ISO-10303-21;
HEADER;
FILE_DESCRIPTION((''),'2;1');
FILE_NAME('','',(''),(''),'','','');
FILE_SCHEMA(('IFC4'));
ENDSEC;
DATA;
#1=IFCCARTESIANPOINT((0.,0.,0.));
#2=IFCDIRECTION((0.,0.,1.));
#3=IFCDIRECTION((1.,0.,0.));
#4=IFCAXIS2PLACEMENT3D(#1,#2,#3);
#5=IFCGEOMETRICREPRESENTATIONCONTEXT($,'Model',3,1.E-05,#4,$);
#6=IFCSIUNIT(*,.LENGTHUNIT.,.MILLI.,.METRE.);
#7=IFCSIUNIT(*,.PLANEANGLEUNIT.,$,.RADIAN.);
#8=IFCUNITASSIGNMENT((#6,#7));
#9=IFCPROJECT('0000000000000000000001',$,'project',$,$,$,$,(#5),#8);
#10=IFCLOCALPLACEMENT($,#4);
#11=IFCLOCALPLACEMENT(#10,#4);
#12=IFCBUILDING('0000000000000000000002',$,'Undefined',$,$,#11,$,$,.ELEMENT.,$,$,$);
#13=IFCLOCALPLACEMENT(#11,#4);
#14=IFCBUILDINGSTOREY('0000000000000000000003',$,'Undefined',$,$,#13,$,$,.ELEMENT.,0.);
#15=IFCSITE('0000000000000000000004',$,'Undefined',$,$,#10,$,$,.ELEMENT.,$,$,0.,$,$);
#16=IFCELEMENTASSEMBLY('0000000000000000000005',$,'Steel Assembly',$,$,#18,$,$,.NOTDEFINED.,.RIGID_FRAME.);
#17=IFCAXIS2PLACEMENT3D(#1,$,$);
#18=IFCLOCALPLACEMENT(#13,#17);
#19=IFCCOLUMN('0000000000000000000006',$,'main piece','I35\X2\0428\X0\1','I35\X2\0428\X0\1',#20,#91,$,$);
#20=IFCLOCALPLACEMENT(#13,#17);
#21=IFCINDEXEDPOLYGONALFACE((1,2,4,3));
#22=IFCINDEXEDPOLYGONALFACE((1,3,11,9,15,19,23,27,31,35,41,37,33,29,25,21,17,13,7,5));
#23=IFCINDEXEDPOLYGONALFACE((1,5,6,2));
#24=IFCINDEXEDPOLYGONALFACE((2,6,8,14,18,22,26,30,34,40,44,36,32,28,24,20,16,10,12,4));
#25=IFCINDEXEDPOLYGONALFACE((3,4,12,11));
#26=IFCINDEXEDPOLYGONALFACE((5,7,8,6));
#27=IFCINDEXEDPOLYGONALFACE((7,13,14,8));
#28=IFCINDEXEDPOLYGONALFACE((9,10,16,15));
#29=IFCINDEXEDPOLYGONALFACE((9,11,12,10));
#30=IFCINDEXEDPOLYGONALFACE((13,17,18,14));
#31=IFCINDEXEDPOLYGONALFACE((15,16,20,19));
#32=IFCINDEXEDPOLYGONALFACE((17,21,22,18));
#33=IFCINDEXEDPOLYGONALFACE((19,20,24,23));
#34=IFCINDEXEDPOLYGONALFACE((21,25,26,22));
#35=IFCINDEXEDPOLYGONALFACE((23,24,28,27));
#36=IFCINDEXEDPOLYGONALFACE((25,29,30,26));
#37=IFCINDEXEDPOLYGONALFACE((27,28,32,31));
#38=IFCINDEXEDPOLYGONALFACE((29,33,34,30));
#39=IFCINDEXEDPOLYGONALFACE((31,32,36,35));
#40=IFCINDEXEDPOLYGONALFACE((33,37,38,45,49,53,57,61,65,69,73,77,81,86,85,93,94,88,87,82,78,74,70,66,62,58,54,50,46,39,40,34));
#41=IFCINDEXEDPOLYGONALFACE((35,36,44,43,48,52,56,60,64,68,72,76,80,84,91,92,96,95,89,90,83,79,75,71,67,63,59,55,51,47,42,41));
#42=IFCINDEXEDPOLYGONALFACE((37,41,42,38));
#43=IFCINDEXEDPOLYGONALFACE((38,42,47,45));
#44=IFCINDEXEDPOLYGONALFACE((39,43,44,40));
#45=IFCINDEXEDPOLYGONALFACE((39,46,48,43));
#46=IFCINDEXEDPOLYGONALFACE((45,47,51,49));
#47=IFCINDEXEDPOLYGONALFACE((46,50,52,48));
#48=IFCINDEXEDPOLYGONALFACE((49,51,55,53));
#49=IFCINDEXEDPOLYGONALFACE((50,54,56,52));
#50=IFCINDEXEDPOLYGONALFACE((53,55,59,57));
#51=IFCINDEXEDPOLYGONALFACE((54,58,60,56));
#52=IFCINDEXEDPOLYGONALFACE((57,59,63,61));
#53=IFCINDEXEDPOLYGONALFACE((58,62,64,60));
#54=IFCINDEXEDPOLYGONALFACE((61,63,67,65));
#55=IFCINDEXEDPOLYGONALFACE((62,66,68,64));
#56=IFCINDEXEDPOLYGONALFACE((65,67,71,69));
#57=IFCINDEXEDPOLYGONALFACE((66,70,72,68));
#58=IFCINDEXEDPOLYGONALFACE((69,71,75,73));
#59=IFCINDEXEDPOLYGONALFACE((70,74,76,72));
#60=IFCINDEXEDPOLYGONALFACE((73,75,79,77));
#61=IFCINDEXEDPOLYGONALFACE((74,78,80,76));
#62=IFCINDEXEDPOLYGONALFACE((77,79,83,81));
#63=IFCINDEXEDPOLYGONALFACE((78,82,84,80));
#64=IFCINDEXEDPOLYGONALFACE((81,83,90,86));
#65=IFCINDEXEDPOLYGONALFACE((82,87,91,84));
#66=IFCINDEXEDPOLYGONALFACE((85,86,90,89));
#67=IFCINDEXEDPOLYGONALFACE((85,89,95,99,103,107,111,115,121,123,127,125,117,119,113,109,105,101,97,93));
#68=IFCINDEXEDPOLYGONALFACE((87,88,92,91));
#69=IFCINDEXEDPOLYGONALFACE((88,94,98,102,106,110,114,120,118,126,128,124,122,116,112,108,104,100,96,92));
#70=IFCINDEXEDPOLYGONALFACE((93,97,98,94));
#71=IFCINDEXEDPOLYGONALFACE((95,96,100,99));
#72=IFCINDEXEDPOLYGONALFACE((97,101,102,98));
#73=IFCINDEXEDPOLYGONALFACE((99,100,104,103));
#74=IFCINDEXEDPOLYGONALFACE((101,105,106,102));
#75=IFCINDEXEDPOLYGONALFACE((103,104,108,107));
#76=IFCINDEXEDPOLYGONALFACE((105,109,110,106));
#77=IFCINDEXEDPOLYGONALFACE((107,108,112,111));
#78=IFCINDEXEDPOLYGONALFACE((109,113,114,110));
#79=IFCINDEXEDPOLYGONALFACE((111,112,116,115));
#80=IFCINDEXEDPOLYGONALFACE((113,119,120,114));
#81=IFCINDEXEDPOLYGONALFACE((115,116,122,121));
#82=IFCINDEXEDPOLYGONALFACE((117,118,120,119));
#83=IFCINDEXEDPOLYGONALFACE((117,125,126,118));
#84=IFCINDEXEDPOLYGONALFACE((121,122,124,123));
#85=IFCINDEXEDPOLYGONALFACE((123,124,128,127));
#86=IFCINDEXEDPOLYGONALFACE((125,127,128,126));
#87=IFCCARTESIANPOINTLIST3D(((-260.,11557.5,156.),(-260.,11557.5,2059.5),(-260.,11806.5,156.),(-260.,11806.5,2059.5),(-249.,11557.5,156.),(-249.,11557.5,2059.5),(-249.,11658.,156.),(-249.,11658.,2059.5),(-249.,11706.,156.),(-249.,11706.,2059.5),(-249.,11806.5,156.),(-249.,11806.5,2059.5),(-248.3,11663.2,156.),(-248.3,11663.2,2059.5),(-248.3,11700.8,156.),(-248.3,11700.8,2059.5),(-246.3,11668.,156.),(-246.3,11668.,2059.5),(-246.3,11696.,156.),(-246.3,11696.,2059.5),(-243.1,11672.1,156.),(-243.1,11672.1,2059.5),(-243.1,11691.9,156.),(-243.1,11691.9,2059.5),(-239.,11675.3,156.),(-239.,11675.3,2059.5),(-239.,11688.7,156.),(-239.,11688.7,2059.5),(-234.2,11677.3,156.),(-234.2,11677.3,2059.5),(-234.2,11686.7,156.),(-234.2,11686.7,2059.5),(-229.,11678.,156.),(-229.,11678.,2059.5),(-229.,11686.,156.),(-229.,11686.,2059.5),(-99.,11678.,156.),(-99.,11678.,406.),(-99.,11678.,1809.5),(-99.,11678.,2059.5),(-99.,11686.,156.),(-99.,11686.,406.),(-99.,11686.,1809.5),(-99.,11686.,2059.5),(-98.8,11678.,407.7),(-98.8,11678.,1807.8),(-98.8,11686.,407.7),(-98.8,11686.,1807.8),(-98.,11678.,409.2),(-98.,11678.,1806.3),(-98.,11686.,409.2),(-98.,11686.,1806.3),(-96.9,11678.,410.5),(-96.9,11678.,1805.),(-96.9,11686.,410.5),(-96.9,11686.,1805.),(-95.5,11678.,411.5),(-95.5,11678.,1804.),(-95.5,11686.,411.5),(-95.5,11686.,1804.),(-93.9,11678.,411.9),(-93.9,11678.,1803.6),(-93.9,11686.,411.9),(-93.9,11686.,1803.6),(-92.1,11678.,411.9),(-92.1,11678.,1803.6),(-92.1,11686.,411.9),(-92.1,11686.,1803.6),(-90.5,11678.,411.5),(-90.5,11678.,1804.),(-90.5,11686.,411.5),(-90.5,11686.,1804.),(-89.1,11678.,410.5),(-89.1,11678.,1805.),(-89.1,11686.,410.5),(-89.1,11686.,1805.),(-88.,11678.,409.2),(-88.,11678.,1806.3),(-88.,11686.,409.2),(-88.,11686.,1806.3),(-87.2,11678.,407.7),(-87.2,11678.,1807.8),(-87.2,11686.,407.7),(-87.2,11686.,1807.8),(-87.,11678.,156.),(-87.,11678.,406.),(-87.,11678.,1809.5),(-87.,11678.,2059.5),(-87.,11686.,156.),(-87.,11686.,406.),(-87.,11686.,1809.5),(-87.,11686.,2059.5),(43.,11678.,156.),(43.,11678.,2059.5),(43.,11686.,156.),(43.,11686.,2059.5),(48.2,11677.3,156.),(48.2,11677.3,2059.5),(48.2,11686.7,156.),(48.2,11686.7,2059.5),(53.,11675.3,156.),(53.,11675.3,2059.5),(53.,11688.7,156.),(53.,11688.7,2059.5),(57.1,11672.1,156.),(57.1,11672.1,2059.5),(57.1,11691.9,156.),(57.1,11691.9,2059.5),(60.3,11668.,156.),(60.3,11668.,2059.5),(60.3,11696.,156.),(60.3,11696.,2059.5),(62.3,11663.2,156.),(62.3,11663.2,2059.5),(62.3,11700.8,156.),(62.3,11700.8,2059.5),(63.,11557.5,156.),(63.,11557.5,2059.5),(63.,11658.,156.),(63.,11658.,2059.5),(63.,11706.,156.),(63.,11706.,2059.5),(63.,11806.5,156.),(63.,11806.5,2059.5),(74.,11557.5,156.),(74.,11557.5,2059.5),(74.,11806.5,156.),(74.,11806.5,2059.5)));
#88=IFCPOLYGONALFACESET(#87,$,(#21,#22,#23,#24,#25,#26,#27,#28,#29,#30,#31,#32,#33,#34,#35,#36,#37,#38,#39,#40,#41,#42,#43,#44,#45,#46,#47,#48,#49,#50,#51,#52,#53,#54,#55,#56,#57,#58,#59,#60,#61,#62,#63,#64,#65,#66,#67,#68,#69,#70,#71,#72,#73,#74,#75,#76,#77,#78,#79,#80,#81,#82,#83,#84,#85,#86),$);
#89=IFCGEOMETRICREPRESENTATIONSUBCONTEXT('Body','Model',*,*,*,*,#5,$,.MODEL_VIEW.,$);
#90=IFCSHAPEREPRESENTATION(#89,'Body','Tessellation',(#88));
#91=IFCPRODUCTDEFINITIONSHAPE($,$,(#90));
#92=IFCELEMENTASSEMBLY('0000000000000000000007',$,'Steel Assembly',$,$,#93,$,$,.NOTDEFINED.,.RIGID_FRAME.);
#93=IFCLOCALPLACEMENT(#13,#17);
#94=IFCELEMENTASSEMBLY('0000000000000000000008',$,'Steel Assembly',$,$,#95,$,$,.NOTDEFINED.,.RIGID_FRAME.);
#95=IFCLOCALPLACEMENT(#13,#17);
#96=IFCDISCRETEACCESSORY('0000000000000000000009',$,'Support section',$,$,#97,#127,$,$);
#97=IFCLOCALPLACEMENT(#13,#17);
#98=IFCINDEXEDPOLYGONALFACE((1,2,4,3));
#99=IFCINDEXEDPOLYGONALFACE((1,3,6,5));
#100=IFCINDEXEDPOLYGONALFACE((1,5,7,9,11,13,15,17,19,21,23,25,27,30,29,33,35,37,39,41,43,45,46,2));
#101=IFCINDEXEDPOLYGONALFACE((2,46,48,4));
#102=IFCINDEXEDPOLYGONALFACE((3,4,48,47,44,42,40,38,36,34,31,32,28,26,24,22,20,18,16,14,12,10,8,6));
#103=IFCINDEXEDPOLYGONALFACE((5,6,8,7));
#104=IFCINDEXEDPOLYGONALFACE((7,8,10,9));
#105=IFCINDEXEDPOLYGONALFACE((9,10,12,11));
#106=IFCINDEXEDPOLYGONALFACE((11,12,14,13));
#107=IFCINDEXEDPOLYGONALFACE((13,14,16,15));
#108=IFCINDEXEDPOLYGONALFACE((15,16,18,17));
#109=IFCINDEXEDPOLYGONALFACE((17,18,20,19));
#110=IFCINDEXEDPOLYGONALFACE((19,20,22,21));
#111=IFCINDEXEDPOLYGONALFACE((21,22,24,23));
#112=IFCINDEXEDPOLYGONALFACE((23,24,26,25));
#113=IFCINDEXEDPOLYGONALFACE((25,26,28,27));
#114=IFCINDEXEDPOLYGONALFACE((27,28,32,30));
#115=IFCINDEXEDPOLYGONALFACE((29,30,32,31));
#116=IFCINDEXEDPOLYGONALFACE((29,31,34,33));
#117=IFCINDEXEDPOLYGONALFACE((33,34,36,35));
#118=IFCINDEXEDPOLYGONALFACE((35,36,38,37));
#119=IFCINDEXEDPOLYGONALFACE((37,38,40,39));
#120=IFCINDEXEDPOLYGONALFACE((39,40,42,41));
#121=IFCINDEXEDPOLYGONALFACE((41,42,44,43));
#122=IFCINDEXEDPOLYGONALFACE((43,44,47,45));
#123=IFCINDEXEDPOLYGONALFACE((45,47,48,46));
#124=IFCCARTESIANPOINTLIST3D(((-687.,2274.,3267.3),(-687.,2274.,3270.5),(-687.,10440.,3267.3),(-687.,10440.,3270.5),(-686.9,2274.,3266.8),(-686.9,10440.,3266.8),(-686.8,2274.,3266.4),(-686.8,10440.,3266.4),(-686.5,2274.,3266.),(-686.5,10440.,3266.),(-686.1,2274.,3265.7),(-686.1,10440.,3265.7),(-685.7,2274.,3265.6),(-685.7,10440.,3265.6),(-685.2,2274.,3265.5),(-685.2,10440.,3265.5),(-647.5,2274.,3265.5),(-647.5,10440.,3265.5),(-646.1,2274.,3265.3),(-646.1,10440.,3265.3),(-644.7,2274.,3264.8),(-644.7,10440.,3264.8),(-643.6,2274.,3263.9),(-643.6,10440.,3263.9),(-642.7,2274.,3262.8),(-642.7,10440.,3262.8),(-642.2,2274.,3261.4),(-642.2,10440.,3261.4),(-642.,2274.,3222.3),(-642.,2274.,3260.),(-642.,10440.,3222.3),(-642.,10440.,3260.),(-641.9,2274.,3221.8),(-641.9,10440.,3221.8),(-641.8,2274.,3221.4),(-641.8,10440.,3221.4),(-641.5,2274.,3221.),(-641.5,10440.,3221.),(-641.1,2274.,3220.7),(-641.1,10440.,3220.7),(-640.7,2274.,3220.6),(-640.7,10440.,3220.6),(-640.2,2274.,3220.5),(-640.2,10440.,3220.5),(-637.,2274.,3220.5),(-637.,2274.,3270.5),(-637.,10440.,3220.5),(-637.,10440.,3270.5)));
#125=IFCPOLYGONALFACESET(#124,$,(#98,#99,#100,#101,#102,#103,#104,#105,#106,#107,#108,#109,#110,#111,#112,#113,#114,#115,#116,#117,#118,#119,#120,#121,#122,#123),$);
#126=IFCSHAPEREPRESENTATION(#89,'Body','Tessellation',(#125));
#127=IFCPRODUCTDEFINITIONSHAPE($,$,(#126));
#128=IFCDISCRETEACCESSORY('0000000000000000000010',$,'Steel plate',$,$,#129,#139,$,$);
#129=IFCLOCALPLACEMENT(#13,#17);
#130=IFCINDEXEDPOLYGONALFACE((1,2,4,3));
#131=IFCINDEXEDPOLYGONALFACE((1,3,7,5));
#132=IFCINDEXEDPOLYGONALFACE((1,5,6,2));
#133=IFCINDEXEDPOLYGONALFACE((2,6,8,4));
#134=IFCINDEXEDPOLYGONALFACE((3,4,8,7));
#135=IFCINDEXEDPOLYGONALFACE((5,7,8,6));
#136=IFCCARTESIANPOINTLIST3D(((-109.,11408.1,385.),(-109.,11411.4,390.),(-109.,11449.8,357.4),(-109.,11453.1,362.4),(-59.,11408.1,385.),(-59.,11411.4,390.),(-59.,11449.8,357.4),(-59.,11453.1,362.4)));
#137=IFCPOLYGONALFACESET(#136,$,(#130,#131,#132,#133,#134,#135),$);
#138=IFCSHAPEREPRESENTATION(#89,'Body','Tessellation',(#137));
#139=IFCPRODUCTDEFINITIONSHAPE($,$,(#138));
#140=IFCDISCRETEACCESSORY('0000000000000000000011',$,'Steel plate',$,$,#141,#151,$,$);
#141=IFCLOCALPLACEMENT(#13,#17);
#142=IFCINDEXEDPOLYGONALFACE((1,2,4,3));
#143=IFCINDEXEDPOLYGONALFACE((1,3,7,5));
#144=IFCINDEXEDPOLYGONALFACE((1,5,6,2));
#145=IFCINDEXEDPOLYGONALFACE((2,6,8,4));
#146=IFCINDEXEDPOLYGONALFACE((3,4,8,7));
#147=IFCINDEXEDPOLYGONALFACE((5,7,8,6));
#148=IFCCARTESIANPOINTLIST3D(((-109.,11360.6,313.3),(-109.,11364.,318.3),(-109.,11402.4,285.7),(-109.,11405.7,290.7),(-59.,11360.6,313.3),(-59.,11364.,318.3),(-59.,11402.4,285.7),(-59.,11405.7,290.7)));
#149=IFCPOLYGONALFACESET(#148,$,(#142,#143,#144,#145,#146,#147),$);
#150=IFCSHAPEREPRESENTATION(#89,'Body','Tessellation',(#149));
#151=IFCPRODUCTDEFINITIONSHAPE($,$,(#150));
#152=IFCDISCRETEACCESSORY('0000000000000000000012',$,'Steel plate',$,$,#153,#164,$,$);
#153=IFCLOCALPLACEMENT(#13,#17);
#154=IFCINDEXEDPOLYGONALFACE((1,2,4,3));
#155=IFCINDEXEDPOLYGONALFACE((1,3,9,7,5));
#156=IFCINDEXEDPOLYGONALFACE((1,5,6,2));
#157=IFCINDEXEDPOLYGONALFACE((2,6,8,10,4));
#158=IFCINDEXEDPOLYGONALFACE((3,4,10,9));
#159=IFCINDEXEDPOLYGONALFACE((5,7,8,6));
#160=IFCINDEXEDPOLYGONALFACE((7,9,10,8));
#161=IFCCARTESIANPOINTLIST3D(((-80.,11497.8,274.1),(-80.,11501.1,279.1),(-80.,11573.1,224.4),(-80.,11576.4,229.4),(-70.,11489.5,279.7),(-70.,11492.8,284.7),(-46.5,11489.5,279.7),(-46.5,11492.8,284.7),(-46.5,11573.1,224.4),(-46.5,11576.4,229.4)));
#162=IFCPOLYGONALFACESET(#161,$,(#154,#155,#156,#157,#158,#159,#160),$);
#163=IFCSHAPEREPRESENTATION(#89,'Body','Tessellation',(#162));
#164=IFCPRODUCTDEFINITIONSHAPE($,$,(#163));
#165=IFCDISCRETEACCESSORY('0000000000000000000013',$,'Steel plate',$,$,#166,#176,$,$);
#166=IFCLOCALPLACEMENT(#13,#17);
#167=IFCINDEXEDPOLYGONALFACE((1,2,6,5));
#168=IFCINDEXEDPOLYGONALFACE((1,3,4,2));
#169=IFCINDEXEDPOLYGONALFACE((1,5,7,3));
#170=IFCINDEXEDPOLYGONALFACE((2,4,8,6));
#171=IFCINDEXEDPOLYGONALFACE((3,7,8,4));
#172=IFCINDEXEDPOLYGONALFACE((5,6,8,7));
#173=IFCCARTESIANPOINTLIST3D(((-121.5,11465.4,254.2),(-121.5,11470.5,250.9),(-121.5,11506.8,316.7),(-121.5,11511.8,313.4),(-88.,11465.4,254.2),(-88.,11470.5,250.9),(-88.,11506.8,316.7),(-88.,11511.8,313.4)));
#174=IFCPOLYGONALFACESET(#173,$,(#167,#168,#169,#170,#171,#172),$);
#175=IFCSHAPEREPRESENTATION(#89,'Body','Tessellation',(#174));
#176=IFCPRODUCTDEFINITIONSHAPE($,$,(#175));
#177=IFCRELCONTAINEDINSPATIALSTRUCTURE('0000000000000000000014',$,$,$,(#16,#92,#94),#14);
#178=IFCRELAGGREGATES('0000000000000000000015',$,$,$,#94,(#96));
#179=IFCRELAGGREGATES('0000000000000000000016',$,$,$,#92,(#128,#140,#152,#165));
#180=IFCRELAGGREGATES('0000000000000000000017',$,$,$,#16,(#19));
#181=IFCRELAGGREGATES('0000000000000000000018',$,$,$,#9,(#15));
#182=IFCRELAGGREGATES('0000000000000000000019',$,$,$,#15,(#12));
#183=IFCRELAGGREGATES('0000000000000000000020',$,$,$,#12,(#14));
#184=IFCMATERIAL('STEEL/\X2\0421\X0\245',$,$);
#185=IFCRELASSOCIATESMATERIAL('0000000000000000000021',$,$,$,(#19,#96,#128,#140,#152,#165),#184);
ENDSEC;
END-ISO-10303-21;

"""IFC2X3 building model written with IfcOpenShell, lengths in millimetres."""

from ifc_helpers import new_model, si_unit, frame, frame_2d, origin_with_axes, origin_2d_with_axis, place, context, subcontext, project, spatial, polyline, circle_curve, parameter, trimmed, segment, composite_curve, i_section, l_section, outline, extrude, clip, halfspace, material, element, aggregate, save


model = new_model("IFC2X3")

# Units and contexts
model_context = context("Model", 3, precision=1e-05, world=origin_with_axes())
body_context = subcontext(model_context, "Body", "Model", "MODEL_VIEW")
ifc_project = project(units=[si_unit("LENGTHUNIT", "METRE", prefix="MILLI"), si_unit("PLANEANGLEUNIT", "RADIAN")], contexts=[model_context])

# Site, building, storey
site_placement = place(None, origin_with_axes())
site = spatial("IfcSite", under=ifc_project, at=site_placement, Name="Undefined", CompositionType="ELEMENT", RefElevation=0.0)
building_placement = place(site_placement, origin_with_axes())
building = spatial("IfcBuilding", under=site, at=building_placement, Name="Undefined", CompositionType="ELEMENT")
storey_placement = place(building_placement, origin_with_axes())
storey = spatial("IfcBuildingStorey", under=building, at=storey_placement, Name="Undefined", CompositionType="ELEMENT", Elevation=0.0)

# Element assembly, column, openings
assembly_1_placement = place(storey_placement, origin_with_axes())
assembly_1 = element("IfcElementAssembly", 1, at=assembly_1_placement, inside=storey, Name="Steel Assembly", AssemblyPlace="NOTDEFINED", PredefinedType="RIGID_FRAME")
ifc_material_1 = material(Name="STEEL/С245")
column_placement = place(assembly_1_placement, frame((-93.0, 11682.0, 156.0), z_axis=(0.0, 0.0, 1.0), x_axis=(1.0, 0.0, 0.0)))
column = element("IfcColumn", 2, at=column_placement, material=ifc_material_1, Name="main piece", Description="I35Ш1", ObjectType="I35Ш1", context=body_context, shape_type="Clipping", body=[
    clip(clip(extrude(i_section(OverallWidth=249.0, OverallDepth=334.0, WebThickness=8.0, FlangeThickness=11.0, FilletRadius=20.0, at=origin_2d_with_axis()), frame((0.0, 0.0, 1903.5), z_axis=(0.0, 0.0, -1.0), x_axis=(0.0, 1.0, 0.0)), (0.0, 0.0, 1.0), 1903.5), halfspace(frame((274.0, -0.6, 1903.5), z_axis=(0.0, 0.0, -1.0), x_axis=(0.0, 1.0, 0.0)), True)), halfspace(frame((274.0, 0.6, 0.0), z_axis=(0.0, 0.0, 1.0), x_axis=(0.0, -1.0, 0.0)), True)),
])
opening_1_placement = place(assembly_1_placement, frame((-93.0, 11682.0, 156.0), z_axis=(0.0, 0.0, 1.0), x_axis=(1.0, 0.0, 0.0)))
element("IfcOpeningElement", 3, at=opening_1_placement, cuts=column, ObjectType="Recess", context=body_context, shape_type="SweptSolid", body=[
    extrude(outline(composite_curve([segment(polyline([(0.0, 0.0), (250.0, 0.0)]), True, "CONTINUOUS"), segment(trimmed(circle_curve(frame_2d((250.0, 6.0), x_axis=(-0.000939, -1.0)), 6.0), [parameter(0.0)], [parameter(3.14347)], True, "PARAMETER"), True, "CONTINUOUS"), segment(polyline([(250.0, 12.0), (0.0, 12.0), (0.0, 0.0)]), True, "DISCONTINUOUS")], self_intersect=False)), frame((-6.0, -102.5, 0.0), z_axis=(0.0, 1.0, 0.0), x_axis=(0.0, 0.0, 1.0)), (0.0, 0.0, 1.0), 205.0),
])
opening_2_placement = place(assembly_1_placement, frame((-93.0, 11682.0, 156.0), z_axis=(0.0, 0.0, 1.0), x_axis=(1.0, 0.0, 0.0)))
element("IfcOpeningElement", 4, at=opening_2_placement, cuts=column, ObjectType="Recess", context=body_context, shape_type="SweptSolid", body=[
    extrude(outline(composite_curve([segment(polyline([(0.0, 0.0), (250.0, 0.0)]), True, "CONTINUOUS"), segment(trimmed(circle_curve(frame_2d((250.0, 6.0), x_axis=(-0.000939, -1.0)), 6.0), [parameter(0.0)], [parameter(3.14347)], True, "PARAMETER"), True, "CONTINUOUS"), segment(polyline([(250.0, 12.0), (0.0, 12.0), (0.0, 0.0)]), True, "DISCONTINUOUS")], self_intersect=False)), frame((-6.0, 102.5, 1903.5), z_axis=(0.0, -1.0, 0.0), x_axis=(0.0, 0.0, -1.0)), (0.0, 0.0, 1.0), 205.0),
])

# Element assembly
assembly_2_placement = place(storey_placement, origin_with_axes())
assembly_2 = element("IfcElementAssembly", 5, at=assembly_2_placement, inside=storey, Name="Steel Assembly", AssemblyPlace="NOTDEFINED", PredefinedType="RIGID_FRAME")

# Element assembly, discrete accessory
assembly_3_placement = place(storey_placement, origin_with_axes())
assembly_3 = element("IfcElementAssembly", 6, at=assembly_3_placement, inside=storey, Name="Steel Assembly", AssemblyPlace="NOTDEFINED", PredefinedType="RIGID_FRAME")
discrete_accessory_1_placement = place(assembly_3_placement, frame((-662.0, 10440.0, 3245.5), z_axis=(-1.0, 0.0, 0.0), x_axis=(0.0, -1.0, 0.0)))
discrete_accessory_1 = element("IfcDiscreteAccessory", 7, at=discrete_accessory_1_placement, material=ifc_material_1, Name="Support section", context=body_context, shape_type="SweptSolid", body=[
    extrude(l_section(Depth=50.0, Width=50.0, Thickness=5.0, FilletRadius=5.5, EdgeRadius=1.8, at=origin_2d_with_axis()), frame((8166.0, 0.0, 0.0), z_axis=(-1.0, 0.0, 0.0), x_axis=(0.0, -1.0, 0.0)), (0.0, 0.0, 1.0), 8166.0),
])
aggregate(assembly_3, [discrete_accessory_1])

# Discrete accessories
discrete_accessory_2_placement = place(assembly_2_placement, frame((-59.0, 11409.7, 387.5), z_axis=(0.0, 0.551387, 0.83425), x_axis=(0.0, 0.83425, -0.551387)))
discrete_accessory_2 = element("IfcDiscreteAccessory", 8, at=discrete_accessory_2_placement, material=ifc_material_1, Name="Steel plate", context=body_context, shape_type="SweptSolid", body=[
    extrude(outline(polyline([(0.0, 0.0), (50.0, 0.0), (50.0, 50.0), (0.0, 50.0), (0.0, 0.0)])), frame((0.0, 0.0, -3.0), z_axis=(0.0, 0.0, 1.0), x_axis=(1.0, 0.0, 0.0)), (0.0, 0.0, 1.0), 6.0),
])
discrete_accessory_3_placement = place(assembly_2_placement, frame((-59.0, 11362.3, 315.8), z_axis=(0.0, 0.551387, 0.83425), x_axis=(0.0, 0.83425, -0.551387)))
discrete_accessory_3 = element("IfcDiscreteAccessory", 9, at=discrete_accessory_3_placement, material=ifc_material_1, Name="Steel plate", context=body_context, shape_type="SweptSolid", body=[
    extrude(outline(polyline([(0.0, 0.0), (50.0, 0.0), (50.0, 50.0), (0.0, 50.0), (0.0, 0.0)])), frame((0.0, 0.0, -3.0), z_axis=(0.0, 0.0, 1.0), x_axis=(1.0, 0.0, 0.0)), (0.0, 0.0, 1.0), 6.0),
])
discrete_accessory_4_placement = place(assembly_2_placement, frame((-46.5, 11491.1, 282.2), z_axis=(0.0, 0.551387, 0.83425), x_axis=(0.0, 0.83425, -0.551387)))
discrete_accessory_4 = element("IfcDiscreteAccessory", 10, at=discrete_accessory_4_placement, material=ifc_material_1, Name="Steel plate", context=body_context, shape_type="SweptSolid", body=[
    extrude(outline(polyline([(0.0, 0.0), (100.2, 0.0), (100.2, 33.5), (10.0, 33.5), (0.0, 23.5), (0.0, 0.0)])), frame((0.0, 0.0, -3.0), z_axis=(0.0, 0.0, 1.0), x_axis=(1.0, 0.0, 0.0)), (0.0, 0.0, 1.0), 6.0),
])

# Discrete accessory, opening
discrete_accessory_5_placement = place(assembly_2_placement, frame((-121.5, 11509.3, 315.1), z_axis=(0.0, -0.83425, 0.551387), x_axis=(0.0, -0.551387, -0.83425)))
discrete_accessory_5 = element("IfcDiscreteAccessory", 11, at=discrete_accessory_5_placement, material=ifc_material_1, Name="Steel plate", context=body_context, shape_type="SweptSolid", body=[
    extrude(outline(polyline([(0.0, 0.0), (75.0, 0.0), (75.0, 75.0), (0.0, 75.0), (0.0, 0.0)])), frame((0.0, 0.0, -3.0), z_axis=(0.0, 0.0, 1.0), x_axis=(1.0, 0.0, 0.0)), (0.0, 0.0, 1.0), 6.0),
])
opening_3_placement = place(assembly_2_placement, frame((-121.5, 11509.3, 315.1), z_axis=(0.0, -0.83425, 0.551387), x_axis=(0.0, -0.551387, -0.83425)))
element("IfcOpeningElement", 12, at=opening_3_placement, cuts=discrete_accessory_5, ObjectType="Recess", context=body_context, shape_type="SweptSolid", body=[
    extrude(outline(polyline([(0.0, 0.0), (75.0, 0.0), (75.0, 150.0), (0.0, 150.0), (0.0, 0.0)])), frame((-37.5, 108.5, -6.0), z_axis=(0.0, 0.0, 1.0), x_axis=(0.0, -1.0, 0.0)), (0.0, 0.0, 1.0), 12.0),
])
aggregate(assembly_2, [discrete_accessory_2, discrete_accessory_3, discrete_accessory_4, discrete_accessory_5])

aggregate(assembly_1, [column])

save(model, "model.ifc")
